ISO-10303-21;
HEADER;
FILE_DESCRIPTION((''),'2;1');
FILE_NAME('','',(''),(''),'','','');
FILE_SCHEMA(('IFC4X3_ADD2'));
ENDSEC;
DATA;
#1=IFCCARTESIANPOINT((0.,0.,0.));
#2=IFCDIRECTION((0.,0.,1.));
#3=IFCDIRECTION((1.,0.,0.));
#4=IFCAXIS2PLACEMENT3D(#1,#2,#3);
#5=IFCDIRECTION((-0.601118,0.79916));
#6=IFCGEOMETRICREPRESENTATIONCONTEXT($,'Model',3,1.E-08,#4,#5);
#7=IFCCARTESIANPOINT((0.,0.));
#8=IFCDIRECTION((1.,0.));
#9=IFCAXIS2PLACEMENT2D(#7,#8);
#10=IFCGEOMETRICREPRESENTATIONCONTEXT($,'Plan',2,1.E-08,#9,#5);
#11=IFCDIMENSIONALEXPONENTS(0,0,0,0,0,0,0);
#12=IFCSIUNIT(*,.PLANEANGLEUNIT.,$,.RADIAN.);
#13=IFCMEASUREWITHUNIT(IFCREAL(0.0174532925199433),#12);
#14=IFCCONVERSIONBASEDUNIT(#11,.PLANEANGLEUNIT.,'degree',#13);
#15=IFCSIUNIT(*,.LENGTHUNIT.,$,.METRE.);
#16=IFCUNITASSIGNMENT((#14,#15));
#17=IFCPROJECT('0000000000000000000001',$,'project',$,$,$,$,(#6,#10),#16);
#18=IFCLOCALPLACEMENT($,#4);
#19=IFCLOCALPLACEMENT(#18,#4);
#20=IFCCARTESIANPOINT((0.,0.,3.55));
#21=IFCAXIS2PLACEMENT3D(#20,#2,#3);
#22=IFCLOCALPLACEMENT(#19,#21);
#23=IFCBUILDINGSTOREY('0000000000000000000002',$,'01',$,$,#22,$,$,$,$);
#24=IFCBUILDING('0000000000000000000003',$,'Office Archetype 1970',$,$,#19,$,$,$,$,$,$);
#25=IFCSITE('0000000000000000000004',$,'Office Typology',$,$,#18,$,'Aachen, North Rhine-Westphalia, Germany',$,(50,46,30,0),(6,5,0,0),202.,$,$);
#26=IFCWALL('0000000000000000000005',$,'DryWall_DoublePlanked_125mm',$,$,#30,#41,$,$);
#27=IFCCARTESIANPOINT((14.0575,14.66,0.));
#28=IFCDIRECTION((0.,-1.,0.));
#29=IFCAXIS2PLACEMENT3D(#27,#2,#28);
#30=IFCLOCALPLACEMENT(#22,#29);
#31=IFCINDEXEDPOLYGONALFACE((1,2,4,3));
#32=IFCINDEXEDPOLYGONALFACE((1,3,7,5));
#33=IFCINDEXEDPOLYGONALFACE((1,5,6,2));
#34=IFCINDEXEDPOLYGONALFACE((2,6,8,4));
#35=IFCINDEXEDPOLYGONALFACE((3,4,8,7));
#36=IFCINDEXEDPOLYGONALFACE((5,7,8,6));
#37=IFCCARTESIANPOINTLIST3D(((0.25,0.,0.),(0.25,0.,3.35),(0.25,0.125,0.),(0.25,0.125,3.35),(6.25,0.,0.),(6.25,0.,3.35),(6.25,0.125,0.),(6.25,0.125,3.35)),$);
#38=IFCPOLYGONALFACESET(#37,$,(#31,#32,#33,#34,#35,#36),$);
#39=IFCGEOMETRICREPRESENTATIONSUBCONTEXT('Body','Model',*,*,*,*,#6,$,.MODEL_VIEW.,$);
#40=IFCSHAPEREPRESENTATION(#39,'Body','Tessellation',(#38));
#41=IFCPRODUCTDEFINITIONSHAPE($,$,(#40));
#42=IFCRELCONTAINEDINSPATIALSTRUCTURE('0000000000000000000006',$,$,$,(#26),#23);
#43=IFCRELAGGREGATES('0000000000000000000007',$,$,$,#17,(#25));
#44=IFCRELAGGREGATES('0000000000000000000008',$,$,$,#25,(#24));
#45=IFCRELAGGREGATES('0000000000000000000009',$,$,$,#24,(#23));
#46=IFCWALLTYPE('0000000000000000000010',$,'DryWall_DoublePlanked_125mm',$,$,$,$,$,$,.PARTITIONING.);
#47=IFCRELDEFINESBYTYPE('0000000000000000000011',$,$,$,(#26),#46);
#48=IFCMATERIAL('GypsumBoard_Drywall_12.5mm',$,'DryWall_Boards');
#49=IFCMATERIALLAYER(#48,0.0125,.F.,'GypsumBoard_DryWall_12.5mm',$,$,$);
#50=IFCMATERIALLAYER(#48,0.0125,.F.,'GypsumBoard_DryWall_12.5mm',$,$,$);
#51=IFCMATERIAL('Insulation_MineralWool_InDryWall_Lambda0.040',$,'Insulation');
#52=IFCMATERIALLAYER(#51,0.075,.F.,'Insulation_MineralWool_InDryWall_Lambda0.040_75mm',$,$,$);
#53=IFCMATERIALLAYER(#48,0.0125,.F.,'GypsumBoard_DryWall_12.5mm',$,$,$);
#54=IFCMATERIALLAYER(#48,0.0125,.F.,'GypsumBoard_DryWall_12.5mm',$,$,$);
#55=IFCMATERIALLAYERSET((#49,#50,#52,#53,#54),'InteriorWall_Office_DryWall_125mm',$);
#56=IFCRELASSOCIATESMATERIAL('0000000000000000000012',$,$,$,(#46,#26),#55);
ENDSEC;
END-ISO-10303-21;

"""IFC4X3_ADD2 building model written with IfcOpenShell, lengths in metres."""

from ifc_helpers import new_model, entity, si_unit, converted_unit, direction, frame, origin_with_axes, origin_2d_with_axis, place, context, subcontext, project, spatial, line, indexed_curve, outline, extrude, material, layer, layer_set, layer_usage, type_object, element, save


model = new_model("IFC4X3_ADD2")

# Units and contexts
model_context = context("Model", 3, precision=1e-08, world=origin_with_axes(), true_north=direction((-0.601118, 0.79916)))
plan_context = context("Plan", 2, precision=1e-08, world=origin_2d_with_axis(), true_north=direction((-0.601118, 0.79916)))
body_context = subcontext(model_context, "Body", "Model", "MODEL_VIEW")
ifc_project = project(units=[converted_unit("PLANEANGLEUNIT", "degree", entity("IfcReal", 0.0174532925199433), si_unit("PLANEANGLEUNIT", "RADIAN"), dimensions=[0, 0, 0, 0, 0, 0, 0]), si_unit("LENGTHUNIT", "METRE")], contexts=[model_context, plan_context])

# Site, building, storey
site_placement = place(None, origin_with_axes())
site = spatial("IfcSite", under=ifc_project, at=site_placement, Name="Office Typology", LongName="Aachen, North Rhine-Westphalia, Germany", RefLatitude=(50, 46, 30, 0), RefLongitude=(6, 5, 0, 0), RefElevation=202.0)
building_placement = place(site_placement, origin_with_axes())
building = spatial("IfcBuilding", under=site, at=building_placement, Name="Office Archetype 1970")
storey_placement = place(building_placement, frame((0.0, 0.0, 3.55), z_axis=(0.0, 0.0, 1.0), x_axis=(1.0, 0.0, 0.0)))
storey = spatial("IfcBuildingStorey", under=building, at=storey_placement, Name="01")

# Wall
ifc_material_1 = material(Name="GypsumBoard_Drywall_12.5mm", Category="DryWall_Boards")
ifc_layer_1 = layer(ifc_material_1, 0.0125, ventilated=False, Name="GypsumBoard_DryWall_12.5mm")
ifc_layer_2 = layer(ifc_material_1, 0.0125, ventilated=False, Name="GypsumBoard_DryWall_12.5mm")
ifc_material_2 = material(Name="Insulation_MineralWool_InDryWall_Lambda0.040", Category="Insulation")
ifc_layer_3 = layer(ifc_material_2, 0.075, ventilated=False, Name="Insulation_MineralWool_InDryWall_Lambda0.040_75mm")
ifc_layer_4 = layer(ifc_material_1, 0.0125, ventilated=False, Name="GypsumBoard_DryWall_12.5mm")
ifc_layer_5 = layer(ifc_material_1, 0.0125, ventilated=False, Name="GypsumBoard_DryWall_12.5mm")
ifc_layer_set_1 = layer_set([ifc_layer_1, ifc_layer_2, ifc_layer_3, ifc_layer_4, ifc_layer_5], Name="InteriorWall_Office_DryWall_125mm")
ifc_layer_usage = layer_usage(ifc_layer_set_1, "AXIS2", "POSITIVE", 0.0)
wall_type_1 = type_object("IfcWallType", Name="DryWall_DoublePlanked_125mm", PredefinedType="PARTITIONING", material=ifc_layer_set_1)
wall_1_placement = place(storey_placement, frame((14.0575, 14.66, 0.0), z_axis=(0.0, 0.0, 1.0), x_axis=(0.0, -1.0, 0.0)))
element("IfcWall", 1, at=wall_1_placement, inside=storey, type_object=wall_type_1, material=ifc_layer_usage, Name="DryWall_DoublePlanked_125mm", context=body_context, shape_type="SweptSolid", body=[
    extrude(outline(indexed_curve([(0.25, 0.0), (0.25, 0.125), (6.25, 0.125), (6.25, 0.0)], segments=[line(1, 2, 3, 4, 1)])), origin_with_axes(), (0.0, 0.0, 1.0), 3.35),
])

save(model, "model.ifc")
